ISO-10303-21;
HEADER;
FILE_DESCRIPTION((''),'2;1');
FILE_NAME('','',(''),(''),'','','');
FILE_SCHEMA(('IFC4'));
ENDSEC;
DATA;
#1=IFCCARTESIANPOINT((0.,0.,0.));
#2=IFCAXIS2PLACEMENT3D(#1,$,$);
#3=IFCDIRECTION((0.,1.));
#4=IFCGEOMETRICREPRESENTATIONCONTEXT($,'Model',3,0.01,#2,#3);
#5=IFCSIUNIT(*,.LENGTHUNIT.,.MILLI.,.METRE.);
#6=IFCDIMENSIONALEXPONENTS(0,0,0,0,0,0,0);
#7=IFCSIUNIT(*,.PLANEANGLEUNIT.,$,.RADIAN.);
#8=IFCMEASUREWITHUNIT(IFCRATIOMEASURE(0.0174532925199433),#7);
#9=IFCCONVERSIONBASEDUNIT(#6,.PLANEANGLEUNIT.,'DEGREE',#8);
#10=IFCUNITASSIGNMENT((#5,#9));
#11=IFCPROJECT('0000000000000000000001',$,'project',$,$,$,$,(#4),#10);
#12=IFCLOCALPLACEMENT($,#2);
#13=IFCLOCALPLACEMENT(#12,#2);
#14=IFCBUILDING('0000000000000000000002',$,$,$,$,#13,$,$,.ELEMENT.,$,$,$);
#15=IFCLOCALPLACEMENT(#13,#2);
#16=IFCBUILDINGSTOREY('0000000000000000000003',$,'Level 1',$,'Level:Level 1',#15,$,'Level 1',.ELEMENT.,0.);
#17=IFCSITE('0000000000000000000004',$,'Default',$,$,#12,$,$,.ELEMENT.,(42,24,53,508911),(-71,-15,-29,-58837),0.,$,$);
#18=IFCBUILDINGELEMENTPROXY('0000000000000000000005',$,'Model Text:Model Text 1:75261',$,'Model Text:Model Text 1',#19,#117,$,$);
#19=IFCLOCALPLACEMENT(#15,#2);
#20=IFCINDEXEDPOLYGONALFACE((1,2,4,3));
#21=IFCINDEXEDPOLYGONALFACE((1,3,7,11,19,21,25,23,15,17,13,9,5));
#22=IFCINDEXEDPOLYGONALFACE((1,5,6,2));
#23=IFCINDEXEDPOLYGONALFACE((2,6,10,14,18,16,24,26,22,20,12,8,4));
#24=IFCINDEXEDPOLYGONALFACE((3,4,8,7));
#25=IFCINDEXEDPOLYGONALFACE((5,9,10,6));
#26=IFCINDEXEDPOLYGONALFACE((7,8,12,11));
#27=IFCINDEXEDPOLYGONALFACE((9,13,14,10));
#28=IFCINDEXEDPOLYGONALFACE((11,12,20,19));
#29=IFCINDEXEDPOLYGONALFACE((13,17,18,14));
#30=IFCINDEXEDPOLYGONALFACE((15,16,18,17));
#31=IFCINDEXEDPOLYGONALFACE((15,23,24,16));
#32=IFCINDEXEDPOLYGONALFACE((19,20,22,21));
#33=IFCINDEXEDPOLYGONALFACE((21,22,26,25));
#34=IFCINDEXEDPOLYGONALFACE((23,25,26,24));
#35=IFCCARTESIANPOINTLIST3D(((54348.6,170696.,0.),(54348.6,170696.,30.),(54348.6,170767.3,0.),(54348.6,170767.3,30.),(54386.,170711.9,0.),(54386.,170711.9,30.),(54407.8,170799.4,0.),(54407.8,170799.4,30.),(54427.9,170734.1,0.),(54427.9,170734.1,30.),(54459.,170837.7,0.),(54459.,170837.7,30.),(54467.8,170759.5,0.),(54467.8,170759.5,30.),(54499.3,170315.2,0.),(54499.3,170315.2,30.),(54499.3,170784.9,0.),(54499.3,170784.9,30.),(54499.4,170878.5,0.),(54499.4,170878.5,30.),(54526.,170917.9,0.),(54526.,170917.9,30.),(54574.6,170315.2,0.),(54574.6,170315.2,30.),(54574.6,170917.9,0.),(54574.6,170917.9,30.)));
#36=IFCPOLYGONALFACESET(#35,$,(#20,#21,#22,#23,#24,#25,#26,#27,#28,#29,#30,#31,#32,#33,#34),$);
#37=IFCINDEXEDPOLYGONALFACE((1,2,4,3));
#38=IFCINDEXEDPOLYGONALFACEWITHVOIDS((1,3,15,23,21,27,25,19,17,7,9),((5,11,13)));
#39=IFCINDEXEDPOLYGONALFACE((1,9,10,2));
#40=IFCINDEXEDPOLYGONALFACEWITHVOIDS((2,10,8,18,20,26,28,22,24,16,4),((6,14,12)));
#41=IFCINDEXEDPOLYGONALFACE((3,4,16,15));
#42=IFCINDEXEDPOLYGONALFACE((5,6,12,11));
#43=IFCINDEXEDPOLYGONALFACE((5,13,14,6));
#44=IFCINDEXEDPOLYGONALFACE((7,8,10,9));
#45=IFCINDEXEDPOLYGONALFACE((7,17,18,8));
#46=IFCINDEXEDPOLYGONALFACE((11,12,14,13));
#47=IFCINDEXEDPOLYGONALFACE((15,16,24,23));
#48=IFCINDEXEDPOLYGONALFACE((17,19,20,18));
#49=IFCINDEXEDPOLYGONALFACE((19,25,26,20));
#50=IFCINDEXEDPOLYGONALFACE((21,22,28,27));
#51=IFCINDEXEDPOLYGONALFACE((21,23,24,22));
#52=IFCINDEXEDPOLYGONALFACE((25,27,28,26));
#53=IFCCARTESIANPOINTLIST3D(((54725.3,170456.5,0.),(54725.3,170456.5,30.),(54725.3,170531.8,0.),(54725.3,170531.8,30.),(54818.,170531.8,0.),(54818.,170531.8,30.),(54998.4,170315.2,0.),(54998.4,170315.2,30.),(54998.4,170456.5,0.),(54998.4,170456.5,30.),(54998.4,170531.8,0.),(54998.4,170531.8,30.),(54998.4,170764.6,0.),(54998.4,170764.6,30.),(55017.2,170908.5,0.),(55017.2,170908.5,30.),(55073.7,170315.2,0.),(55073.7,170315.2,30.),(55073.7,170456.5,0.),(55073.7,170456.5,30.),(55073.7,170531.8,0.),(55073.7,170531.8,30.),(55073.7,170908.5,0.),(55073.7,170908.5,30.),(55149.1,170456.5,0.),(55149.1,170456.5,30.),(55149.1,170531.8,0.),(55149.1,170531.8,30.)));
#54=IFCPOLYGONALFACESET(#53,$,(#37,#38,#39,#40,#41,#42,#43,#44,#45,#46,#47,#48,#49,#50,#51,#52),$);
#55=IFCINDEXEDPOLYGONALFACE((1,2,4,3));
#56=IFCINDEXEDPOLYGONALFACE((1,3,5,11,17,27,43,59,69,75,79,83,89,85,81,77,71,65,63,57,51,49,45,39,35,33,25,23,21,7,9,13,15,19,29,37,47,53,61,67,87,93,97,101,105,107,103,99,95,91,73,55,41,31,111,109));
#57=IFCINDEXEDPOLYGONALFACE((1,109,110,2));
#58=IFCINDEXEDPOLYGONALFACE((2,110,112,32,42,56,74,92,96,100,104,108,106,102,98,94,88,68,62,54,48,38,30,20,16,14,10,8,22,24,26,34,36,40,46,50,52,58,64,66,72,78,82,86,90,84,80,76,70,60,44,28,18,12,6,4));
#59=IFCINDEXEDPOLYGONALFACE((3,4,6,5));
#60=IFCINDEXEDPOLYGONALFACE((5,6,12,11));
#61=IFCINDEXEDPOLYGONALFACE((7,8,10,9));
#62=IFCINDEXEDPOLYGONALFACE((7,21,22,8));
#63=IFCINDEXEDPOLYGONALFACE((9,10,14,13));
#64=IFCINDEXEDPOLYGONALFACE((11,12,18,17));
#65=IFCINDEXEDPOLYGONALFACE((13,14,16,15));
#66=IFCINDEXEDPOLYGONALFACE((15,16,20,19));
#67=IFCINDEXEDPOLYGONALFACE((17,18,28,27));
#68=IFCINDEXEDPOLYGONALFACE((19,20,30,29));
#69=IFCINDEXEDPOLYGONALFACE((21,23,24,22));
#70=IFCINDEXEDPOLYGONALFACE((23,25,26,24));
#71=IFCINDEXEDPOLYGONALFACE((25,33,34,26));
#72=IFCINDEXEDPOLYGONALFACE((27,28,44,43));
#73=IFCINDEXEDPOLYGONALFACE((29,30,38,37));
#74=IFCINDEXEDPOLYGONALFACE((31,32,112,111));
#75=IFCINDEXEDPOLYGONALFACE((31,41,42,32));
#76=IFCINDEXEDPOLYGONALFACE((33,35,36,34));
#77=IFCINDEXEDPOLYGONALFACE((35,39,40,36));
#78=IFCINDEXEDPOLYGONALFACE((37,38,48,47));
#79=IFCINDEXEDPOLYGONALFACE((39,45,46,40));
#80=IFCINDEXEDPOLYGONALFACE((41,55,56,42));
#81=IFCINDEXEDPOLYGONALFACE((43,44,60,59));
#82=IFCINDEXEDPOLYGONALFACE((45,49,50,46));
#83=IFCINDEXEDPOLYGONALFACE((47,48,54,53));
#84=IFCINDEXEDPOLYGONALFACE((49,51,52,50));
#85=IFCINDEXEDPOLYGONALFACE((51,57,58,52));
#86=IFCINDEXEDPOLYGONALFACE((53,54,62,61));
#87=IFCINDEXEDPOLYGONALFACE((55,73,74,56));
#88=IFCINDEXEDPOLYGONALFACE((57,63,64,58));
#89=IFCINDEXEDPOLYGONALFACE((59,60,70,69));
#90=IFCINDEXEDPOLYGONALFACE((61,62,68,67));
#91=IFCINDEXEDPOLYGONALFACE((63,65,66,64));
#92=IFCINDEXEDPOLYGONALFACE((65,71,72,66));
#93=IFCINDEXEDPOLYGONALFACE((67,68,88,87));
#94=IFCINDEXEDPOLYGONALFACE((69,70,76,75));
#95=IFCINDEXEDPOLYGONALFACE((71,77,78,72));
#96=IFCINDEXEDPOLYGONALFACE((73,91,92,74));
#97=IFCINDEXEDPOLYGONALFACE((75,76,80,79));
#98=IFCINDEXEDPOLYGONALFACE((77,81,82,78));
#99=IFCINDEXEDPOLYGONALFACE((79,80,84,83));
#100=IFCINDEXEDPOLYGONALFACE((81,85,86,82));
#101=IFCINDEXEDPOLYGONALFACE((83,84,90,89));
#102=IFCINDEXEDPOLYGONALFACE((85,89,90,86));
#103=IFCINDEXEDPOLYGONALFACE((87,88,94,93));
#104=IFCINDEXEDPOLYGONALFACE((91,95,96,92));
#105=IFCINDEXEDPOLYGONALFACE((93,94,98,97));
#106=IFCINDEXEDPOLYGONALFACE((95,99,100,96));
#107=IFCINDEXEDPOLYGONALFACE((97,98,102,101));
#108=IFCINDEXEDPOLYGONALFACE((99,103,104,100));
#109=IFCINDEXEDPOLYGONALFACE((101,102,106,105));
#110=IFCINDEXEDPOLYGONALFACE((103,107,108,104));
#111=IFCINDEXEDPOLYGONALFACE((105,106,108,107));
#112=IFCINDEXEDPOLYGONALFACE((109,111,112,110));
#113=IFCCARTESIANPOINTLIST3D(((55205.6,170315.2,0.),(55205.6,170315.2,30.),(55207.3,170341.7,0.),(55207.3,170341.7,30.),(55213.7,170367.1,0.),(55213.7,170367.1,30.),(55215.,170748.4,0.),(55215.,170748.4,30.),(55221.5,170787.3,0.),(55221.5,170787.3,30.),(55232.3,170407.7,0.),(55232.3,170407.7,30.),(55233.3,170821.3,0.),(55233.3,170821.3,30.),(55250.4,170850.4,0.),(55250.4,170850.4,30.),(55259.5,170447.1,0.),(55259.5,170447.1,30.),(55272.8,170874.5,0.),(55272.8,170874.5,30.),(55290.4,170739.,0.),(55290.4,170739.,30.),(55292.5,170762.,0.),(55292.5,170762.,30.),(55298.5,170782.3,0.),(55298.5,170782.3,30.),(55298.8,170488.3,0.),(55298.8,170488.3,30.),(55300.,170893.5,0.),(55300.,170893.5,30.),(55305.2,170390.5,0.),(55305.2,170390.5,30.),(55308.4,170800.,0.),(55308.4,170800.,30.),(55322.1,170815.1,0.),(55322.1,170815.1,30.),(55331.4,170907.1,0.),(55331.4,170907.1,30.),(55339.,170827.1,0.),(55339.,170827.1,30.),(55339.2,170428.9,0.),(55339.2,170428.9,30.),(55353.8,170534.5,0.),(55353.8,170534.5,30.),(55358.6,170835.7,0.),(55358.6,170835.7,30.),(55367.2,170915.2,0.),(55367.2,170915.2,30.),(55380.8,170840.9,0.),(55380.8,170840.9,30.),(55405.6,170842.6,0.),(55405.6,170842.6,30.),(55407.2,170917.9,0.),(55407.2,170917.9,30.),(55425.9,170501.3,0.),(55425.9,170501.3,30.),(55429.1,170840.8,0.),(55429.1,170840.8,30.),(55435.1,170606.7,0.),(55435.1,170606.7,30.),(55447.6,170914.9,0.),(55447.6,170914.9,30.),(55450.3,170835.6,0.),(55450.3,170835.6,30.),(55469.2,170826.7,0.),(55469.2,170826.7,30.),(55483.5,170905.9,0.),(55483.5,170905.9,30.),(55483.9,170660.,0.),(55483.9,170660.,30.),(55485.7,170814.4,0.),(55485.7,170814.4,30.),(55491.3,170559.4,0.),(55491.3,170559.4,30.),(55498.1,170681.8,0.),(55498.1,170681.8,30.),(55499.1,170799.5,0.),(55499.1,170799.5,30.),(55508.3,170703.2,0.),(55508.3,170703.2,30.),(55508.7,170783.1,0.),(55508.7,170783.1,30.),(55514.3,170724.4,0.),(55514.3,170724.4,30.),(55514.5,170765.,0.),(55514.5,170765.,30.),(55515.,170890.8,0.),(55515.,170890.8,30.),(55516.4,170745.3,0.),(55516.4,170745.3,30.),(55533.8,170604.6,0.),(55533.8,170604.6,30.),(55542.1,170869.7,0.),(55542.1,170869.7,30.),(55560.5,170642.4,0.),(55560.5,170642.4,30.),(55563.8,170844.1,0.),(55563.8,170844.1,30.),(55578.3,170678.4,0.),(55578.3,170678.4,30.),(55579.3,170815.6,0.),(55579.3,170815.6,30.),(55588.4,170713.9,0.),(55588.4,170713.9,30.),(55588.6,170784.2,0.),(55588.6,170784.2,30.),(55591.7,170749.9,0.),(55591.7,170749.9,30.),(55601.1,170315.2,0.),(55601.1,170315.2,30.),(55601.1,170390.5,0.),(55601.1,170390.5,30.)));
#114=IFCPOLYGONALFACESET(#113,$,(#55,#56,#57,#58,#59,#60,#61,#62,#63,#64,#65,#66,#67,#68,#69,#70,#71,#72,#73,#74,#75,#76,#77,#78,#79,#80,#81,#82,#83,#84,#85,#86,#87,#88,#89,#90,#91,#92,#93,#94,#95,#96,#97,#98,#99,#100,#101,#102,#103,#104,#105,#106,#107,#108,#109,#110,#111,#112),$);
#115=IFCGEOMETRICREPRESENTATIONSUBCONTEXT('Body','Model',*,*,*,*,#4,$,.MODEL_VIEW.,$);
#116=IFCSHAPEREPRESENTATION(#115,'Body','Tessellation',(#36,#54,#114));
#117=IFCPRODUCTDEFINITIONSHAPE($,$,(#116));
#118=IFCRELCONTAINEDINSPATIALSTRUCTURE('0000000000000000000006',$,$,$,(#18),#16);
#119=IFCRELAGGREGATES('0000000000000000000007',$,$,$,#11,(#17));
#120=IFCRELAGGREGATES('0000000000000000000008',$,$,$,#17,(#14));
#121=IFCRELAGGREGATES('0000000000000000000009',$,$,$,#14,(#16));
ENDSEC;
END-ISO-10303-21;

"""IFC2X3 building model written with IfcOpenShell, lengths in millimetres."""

from ifc_helpers import new_model, entity, si_unit, converted_unit, direction, frame, origin, place, context, subcontext, project, spatial, polyline, outline, extrude, element, save


model = new_model("IFC2X3")

# Units and contexts
model_context = context("Model", 3, precision=0.01, world=origin(), true_north=direction((0.0, 1.0)))
body_context = subcontext(model_context, "Body", "Model", "MODEL_VIEW")
ifc_project = project(units=[si_unit("LENGTHUNIT", "METRE", prefix="MILLI"), converted_unit("PLANEANGLEUNIT", "DEGREE", entity("IfcRatioMeasure", 0.0174532925199433), si_unit("PLANEANGLEUNIT", "RADIAN"), dimensions=[0, 0, 0, 0, 0, 0, 0])], contexts=[model_context])

# Site, building, storey
site_placement = place(None, origin())
site = spatial("IfcSite", under=ifc_project, at=site_placement, Name="Default", CompositionType="ELEMENT", RefLatitude=(42, 24, 53, 508911), RefLongitude=(-71, -15, -29, -58837), RefElevation=0.0)
building_placement = place(site_placement, origin())
building = spatial("IfcBuilding", under=site, at=building_placement, CompositionType="ELEMENT")
storey_placement = place(building_placement, origin())
storey = spatial("IfcBuildingStorey", under=building, at=storey_placement, Name="Level 1", ObjectType="Level:Level 1", LongName="Level 1", CompositionType="ELEMENT", Elevation=0.0)

# Building element proxy
proxy_1_placement = place(storey_placement, origin())
element("IfcBuildingElementProxy", 1, at=proxy_1_placement, inside=storey, Name="Model Text:Model Text 1:75261", ObjectType="Model Text:Model Text 1", context=body_context, shape_type="SweptSolid", body=[
    extrude(outline(polyline([(-410.6, -111.6), (192.1, -111.6), (192.1, -63.1), (152.7, -36.4), (111.9, 4.0), (73.6, 55.2), (41.4, 114.4), (-29.8, 114.4), (-13.9, 77.0), (8.3, 35.1), (33.7, -4.8), (59.1, -36.3), (-410.6, -36.3), (-410.6, -111.6)])), frame((54463.0, 170725.8, 0.0), z_axis=(0.0, 0.0, 1.0), x_axis=(0.0, 1.0, 0.0)), (0.0, 0.0, 1.0), 30.0),
    extrude(outline(polyline([(-6.8, -218.3), (68.5, -218.3), (68.5, -77.1), (143.8, -77.1), (143.8, -1.7), (68.5, -1.7), (68.5, 375.0), (12.0, 375.0), (-280.0, -1.7), (-280.0, -77.1), (-6.8, -77.1), (-6.8, -218.3)]), holes=[polyline([(-6.8, -1.7), (-187.3, -1.7), (-6.8, 231.1), (-6.8, -1.7)])]), frame((55005.3, 170533.5, 0.0)), (0.0, 0.0, 1.0), 30.0),
    extrude(outline(polyline([(-190.2, -317.5), (-190.2, -392.8), (205.4, -392.8), (203.7, -366.3), (197.3, -340.9), (178.7, -300.3), (151.5, -260.9), (112.2, -219.7), (57.2, -173.6), (-24.1, -101.3), (-72.9, -48.0), (-87.1, -26.3), (-97.3, -4.8), (-103.4, 16.4), (-105.4, 37.3), (-103.5, 57.0), (-97.7, 75.0), (-88.2, 91.5), (-74.7, 106.4), (-58.2, 118.7), (-39.4, 127.5), (-18.2, 132.8), (5.4, 134.6), (30.2, 132.9), (52.4, 127.7), (72.0, 119.1), (88.9, 107.1), (102.6, 92.0), (112.5, 74.3), (118.5, 54.0), (120.6, 31.0), (196.0, 40.4), (189.5, 79.3), (177.7, 113.3), (160.6, 142.4), (138.2, 166.5), (111.0, 185.5), (79.5, 199.1), (43.8, 207.2), (3.8, 209.9), (-36.6, 206.9), (-72.5, 197.9), (-104.0, 182.8), (-131.1, 161.7), (-152.8, 136.1), (-168.3, 107.6), (-177.6, 76.2), (-180.8, 41.9), (-177.4, 5.8), (-167.4, -29.6), (-149.5, -65.6), (-122.8, -103.4), (-80.3, -148.6), (-14.9, -206.7), (71.8, -279.1), (105.8, -317.5), (-190.2, -317.5)])), frame((55411.0, 170708.0, 0.0), z_axis=(0.0, 0.0, -1.0), x_axis=(-1.0, 0.0, 0.0)), (0.0, 0.0, -1.0), 30.0),
])

save(model, "model.ifc")
